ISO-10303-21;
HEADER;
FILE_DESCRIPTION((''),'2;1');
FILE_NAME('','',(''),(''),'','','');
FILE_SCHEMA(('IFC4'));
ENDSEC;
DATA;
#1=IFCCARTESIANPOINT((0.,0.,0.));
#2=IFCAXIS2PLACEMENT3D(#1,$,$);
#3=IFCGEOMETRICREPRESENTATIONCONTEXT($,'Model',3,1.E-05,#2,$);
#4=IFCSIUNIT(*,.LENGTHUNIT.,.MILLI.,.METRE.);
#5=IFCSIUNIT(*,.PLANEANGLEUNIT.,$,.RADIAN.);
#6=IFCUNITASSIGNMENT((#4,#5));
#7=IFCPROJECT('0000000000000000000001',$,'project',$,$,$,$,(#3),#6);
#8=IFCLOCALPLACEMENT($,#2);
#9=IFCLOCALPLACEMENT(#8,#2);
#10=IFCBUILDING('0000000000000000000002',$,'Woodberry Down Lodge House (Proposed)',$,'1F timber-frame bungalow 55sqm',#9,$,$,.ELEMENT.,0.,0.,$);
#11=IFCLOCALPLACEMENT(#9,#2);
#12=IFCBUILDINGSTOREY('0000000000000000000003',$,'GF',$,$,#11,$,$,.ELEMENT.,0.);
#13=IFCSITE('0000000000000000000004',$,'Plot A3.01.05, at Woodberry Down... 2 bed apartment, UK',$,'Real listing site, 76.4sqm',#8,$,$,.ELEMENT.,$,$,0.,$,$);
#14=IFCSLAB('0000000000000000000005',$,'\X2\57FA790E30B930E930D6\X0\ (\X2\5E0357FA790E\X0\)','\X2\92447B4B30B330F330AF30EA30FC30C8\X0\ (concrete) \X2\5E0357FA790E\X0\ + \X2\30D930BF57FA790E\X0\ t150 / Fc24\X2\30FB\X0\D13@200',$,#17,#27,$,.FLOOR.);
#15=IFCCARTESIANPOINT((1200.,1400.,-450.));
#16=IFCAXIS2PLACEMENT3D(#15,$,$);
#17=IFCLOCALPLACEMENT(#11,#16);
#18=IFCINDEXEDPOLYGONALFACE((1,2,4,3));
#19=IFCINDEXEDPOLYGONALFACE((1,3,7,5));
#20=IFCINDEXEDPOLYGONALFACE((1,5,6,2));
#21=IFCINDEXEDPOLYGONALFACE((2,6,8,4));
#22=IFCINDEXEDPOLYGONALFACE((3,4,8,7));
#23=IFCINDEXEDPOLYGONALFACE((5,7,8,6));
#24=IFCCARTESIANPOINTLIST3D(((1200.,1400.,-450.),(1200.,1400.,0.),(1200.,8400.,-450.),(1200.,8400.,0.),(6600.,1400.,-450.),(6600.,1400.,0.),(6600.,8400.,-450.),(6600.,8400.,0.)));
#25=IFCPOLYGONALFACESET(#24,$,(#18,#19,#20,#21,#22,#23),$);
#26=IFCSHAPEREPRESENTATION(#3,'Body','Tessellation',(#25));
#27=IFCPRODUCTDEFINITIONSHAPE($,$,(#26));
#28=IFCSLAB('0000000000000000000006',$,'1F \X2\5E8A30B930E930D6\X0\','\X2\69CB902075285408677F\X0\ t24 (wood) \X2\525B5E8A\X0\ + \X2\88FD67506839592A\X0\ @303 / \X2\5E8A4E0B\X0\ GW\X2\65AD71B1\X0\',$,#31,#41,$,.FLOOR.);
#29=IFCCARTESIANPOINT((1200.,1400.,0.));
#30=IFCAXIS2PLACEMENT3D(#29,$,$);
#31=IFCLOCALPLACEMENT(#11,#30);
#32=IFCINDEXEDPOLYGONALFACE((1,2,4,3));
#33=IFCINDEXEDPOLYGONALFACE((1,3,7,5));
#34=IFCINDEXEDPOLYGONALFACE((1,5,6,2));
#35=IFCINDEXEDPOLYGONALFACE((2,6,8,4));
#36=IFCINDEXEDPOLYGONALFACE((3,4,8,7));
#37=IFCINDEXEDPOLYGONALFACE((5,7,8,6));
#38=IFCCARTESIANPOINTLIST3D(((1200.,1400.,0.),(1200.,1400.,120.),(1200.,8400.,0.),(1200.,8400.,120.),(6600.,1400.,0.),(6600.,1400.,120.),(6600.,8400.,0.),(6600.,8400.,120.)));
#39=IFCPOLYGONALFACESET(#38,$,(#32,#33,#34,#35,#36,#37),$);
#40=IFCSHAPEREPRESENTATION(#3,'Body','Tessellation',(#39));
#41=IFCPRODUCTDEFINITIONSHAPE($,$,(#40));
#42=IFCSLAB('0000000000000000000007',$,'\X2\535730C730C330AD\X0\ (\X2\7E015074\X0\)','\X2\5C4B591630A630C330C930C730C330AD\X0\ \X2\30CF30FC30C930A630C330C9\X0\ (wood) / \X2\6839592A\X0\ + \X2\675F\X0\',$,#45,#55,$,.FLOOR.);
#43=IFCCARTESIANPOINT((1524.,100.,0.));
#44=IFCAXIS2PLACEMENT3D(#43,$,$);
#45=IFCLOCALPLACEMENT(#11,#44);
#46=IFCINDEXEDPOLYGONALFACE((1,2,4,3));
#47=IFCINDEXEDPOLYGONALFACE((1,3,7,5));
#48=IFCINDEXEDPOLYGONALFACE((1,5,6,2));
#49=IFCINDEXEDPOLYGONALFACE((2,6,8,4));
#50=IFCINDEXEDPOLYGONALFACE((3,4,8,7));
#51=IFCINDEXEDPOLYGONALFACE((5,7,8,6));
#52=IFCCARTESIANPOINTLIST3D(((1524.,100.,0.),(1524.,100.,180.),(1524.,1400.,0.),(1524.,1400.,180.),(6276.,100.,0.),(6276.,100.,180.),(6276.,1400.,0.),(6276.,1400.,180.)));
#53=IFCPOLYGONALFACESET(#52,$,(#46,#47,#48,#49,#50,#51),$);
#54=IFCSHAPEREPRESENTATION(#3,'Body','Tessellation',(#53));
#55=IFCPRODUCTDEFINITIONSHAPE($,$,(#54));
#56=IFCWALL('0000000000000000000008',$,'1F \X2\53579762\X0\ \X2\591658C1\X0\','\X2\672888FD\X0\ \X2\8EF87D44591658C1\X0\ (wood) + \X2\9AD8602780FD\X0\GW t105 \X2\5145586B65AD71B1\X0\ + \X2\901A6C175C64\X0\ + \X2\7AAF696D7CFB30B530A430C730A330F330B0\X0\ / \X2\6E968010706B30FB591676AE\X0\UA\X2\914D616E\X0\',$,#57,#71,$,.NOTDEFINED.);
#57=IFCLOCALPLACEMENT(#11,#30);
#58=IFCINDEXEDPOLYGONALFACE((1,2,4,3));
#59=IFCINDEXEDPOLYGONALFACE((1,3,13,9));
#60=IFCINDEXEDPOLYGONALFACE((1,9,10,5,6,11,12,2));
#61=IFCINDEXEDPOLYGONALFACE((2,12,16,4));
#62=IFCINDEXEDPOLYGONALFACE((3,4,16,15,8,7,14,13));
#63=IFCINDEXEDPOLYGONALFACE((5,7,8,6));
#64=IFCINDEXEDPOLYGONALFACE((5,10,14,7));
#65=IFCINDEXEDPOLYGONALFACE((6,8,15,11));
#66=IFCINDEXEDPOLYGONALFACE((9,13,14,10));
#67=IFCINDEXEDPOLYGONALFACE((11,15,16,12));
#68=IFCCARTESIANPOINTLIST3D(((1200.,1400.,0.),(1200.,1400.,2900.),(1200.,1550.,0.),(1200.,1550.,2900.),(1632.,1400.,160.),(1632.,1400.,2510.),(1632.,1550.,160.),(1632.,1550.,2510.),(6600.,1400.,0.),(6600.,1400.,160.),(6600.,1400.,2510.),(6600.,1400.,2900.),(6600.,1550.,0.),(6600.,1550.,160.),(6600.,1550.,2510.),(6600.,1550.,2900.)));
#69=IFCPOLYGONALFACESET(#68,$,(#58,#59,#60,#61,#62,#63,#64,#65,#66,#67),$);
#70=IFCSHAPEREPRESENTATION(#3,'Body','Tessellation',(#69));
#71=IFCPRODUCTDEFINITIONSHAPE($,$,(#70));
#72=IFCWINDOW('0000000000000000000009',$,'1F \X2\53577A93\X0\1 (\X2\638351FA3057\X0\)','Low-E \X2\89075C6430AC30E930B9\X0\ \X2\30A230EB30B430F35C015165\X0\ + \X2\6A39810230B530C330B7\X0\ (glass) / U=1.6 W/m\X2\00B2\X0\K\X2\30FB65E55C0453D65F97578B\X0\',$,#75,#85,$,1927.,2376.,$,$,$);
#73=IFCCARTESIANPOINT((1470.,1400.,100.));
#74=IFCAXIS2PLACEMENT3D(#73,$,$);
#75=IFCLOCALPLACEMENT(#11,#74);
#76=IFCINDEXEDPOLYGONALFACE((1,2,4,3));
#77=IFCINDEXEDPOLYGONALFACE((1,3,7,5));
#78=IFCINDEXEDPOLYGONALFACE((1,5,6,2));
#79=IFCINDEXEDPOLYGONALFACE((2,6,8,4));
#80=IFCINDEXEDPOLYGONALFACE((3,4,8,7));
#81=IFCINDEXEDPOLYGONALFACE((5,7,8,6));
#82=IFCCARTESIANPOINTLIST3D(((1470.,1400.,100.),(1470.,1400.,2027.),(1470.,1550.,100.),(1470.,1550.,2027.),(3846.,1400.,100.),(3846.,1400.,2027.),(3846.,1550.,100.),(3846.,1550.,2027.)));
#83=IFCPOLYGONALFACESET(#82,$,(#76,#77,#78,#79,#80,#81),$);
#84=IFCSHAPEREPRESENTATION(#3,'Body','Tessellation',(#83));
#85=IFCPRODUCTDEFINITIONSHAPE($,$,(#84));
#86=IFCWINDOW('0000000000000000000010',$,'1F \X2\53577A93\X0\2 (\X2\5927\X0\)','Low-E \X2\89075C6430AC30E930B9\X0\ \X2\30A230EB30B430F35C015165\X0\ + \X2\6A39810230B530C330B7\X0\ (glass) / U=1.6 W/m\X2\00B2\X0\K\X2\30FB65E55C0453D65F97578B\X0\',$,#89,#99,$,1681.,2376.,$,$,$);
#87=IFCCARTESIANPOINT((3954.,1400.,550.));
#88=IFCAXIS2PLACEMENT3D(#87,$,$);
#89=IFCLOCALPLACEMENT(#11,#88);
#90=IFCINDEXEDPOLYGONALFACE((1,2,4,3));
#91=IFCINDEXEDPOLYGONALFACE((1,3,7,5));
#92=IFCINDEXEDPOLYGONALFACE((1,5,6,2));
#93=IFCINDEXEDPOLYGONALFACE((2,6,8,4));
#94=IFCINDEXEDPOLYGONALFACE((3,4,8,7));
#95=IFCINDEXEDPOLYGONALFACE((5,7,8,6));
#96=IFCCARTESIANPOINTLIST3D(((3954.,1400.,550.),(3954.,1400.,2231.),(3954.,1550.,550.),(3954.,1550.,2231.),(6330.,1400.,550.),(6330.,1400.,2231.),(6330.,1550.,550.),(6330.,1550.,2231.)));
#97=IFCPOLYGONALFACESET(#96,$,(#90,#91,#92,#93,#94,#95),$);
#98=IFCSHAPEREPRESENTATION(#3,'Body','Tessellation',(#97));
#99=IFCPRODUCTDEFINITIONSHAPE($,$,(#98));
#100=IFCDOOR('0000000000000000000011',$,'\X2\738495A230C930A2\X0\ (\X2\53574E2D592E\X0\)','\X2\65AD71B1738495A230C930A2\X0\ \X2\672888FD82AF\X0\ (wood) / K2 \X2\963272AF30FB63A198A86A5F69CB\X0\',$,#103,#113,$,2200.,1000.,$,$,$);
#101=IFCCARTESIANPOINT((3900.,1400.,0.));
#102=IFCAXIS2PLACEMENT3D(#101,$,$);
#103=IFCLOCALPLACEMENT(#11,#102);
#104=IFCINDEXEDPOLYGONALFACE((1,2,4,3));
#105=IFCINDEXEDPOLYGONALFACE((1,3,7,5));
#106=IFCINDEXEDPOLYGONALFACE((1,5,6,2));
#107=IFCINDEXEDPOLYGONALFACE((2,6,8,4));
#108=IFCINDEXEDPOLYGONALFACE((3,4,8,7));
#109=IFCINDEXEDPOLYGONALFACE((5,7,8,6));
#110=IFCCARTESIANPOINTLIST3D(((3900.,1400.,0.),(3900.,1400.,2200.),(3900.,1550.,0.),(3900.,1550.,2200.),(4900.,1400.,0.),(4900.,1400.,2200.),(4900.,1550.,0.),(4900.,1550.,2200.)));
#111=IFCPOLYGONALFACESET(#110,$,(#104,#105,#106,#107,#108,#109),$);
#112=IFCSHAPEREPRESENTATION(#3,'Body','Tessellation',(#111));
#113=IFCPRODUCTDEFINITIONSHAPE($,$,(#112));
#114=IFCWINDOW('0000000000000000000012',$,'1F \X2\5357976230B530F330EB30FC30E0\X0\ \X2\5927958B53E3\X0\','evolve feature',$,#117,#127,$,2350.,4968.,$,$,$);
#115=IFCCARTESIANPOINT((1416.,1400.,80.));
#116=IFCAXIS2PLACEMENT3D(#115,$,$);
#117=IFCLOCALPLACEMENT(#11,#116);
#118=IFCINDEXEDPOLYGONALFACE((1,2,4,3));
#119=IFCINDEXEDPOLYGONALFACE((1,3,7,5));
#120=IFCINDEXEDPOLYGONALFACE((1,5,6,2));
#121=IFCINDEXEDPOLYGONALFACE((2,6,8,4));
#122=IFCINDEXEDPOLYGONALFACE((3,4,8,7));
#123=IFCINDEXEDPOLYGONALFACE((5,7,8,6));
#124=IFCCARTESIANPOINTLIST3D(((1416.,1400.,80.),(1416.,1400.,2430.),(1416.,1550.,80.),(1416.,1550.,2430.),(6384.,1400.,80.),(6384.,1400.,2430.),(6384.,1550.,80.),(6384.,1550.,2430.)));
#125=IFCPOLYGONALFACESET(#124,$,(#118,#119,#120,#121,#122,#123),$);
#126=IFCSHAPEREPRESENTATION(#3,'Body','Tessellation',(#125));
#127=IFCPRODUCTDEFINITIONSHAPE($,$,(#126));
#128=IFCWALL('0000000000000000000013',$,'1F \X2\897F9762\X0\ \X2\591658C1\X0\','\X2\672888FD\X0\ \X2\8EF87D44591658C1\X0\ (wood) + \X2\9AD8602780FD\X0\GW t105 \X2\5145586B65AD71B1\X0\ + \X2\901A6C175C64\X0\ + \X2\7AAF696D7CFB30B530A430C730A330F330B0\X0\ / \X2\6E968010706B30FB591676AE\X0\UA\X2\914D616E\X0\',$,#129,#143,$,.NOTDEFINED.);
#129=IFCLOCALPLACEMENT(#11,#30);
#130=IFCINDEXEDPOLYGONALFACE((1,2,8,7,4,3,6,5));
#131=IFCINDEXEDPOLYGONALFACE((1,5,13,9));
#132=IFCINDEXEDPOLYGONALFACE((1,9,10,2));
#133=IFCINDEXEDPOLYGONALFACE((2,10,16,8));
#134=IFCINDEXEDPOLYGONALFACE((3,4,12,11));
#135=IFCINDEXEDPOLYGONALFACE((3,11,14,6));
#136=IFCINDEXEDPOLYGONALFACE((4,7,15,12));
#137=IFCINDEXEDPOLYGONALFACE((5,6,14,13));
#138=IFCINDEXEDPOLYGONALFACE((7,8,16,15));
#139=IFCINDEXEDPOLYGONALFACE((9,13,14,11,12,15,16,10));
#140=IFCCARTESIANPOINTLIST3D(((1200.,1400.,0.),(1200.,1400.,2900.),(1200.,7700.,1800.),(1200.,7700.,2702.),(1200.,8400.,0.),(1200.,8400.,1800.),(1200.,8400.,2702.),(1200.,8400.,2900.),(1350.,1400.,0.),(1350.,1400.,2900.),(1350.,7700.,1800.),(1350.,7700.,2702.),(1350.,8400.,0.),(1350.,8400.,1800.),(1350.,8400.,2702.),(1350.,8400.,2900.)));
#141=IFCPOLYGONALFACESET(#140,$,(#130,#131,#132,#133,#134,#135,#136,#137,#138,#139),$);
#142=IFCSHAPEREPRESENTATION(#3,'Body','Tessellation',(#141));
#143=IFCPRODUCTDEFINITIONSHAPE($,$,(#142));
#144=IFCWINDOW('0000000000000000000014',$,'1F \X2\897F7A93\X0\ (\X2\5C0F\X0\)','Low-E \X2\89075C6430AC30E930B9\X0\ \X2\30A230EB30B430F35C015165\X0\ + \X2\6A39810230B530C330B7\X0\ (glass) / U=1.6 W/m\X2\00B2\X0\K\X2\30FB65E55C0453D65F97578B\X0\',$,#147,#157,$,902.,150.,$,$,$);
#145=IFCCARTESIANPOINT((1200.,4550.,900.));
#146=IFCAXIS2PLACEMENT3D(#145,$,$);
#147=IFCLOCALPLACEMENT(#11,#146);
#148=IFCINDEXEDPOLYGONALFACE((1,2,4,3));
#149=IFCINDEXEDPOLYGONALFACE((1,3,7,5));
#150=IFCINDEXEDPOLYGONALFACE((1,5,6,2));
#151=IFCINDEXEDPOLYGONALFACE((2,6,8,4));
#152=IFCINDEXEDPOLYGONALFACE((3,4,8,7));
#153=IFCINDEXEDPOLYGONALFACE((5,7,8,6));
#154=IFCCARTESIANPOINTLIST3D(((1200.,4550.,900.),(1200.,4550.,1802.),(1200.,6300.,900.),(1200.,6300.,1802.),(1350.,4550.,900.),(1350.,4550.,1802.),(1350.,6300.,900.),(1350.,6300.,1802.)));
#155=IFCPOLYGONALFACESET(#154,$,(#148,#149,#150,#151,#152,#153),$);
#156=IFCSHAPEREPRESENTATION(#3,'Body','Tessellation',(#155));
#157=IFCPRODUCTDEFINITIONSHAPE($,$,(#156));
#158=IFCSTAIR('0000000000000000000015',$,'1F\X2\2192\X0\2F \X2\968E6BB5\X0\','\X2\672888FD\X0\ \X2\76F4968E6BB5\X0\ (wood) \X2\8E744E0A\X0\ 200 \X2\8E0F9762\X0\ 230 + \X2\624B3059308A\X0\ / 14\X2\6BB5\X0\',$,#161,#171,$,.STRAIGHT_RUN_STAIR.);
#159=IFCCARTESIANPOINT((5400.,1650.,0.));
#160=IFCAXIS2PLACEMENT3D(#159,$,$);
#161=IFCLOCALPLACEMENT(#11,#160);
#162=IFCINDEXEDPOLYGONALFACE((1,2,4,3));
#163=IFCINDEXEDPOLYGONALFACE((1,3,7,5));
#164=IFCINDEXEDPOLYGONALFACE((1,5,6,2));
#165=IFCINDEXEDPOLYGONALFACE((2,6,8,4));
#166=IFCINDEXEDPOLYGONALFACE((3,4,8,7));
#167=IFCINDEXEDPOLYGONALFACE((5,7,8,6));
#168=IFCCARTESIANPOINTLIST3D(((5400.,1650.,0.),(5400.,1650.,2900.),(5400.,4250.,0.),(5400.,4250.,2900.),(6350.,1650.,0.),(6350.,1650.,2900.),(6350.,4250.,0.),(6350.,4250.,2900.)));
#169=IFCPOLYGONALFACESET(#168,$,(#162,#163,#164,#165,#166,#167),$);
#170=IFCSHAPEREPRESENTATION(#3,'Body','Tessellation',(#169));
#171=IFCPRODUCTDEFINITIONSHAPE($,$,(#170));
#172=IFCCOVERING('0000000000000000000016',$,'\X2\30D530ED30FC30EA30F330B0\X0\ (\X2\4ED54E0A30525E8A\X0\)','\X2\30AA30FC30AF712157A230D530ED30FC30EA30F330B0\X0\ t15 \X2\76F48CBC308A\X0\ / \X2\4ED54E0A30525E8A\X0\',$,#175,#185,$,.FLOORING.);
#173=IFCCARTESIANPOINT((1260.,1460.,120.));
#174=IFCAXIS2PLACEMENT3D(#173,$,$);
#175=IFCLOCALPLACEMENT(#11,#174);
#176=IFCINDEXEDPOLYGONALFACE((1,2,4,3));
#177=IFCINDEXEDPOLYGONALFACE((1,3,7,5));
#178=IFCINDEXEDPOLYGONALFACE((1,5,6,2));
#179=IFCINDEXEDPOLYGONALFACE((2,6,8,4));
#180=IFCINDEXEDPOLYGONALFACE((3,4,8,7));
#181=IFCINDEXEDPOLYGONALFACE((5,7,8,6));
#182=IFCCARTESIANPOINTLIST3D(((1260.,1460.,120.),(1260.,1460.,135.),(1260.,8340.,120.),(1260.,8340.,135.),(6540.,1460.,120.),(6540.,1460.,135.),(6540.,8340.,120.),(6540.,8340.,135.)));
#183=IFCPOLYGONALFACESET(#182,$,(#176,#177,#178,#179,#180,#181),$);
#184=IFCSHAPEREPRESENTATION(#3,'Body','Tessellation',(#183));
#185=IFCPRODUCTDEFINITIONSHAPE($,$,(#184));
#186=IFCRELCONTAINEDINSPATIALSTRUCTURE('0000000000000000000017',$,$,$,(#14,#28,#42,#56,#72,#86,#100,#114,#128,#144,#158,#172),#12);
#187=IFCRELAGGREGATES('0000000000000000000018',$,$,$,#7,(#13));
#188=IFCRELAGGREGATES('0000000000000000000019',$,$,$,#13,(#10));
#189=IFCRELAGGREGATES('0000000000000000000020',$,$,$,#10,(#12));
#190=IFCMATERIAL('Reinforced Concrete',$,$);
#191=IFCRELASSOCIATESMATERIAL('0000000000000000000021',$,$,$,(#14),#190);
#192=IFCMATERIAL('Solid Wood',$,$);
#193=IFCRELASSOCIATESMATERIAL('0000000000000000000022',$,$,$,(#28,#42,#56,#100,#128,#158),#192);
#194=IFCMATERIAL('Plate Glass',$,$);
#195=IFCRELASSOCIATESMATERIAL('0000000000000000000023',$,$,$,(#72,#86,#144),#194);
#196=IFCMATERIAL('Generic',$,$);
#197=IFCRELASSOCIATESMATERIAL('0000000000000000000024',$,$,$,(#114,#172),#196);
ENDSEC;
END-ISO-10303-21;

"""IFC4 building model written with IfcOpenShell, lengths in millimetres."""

from ifc_helpers import new_model, si_unit, frame, frame_2d, origin, place, context, project, spatial, rectangle, extrude, material, element, fill, save


model = new_model("IFC4")

# Units and contexts
model_context = context("Model", 3, precision=1e-05, world=origin())
ifc_project = project(units=[si_unit("LENGTHUNIT", "METRE", prefix="MILLI"), si_unit("PLANEANGLEUNIT", "RADIAN")], contexts=[model_context])

# Site, building, storey
site_placement = place(None, origin())
site = spatial("IfcSite", under=ifc_project, at=site_placement, Name="Plot A3.01.05, at Woodberry Down... 2 bed apartment, UK", ObjectType="Real listing site, 76.4sqm", CompositionType="ELEMENT", RefElevation=0.0)
building_placement = place(site_placement, origin())
building = spatial("IfcBuilding", under=site, at=building_placement, Name="Woodberry Down Lodge House (Proposed)", ObjectType="1F timber-frame bungalow 55sqm", CompositionType="ELEMENT", ElevationOfRefHeight=0.0, ElevationOfTerrain=0.0)
storey_placement = place(building_placement, origin())
storey = spatial("IfcBuildingStorey", under=building, at=storey_placement, Name="GF", CompositionType="ELEMENT", Elevation=0.0)

# Slabs
ifc_material_1 = material(Name="Reinforced Concrete")
slab_1_placement = place(storey_placement, frame((1200.0, 1400.0, -450.0)))
element("IfcSlab", 1, at=slab_1_placement, inside=storey, material=ifc_material_1, Name="基礎スラブ (布基礎)", Description="鉄筋コンクリート (concrete) 布基礎 + ベタ基礎 t150 / Fc24・D13@200", PredefinedType="FLOOR", context=model_context, shape_type="SweptSolid", body=[
    extrude(rectangle(XDim=5400.0, YDim=7000.0, at=frame_2d((2700.0, 3500.0))), frame((1200.0, 1400.0, -450.0)), (0.0, 0.0, 1.0), 450.0),
])
ifc_material_2 = material(Name="Solid Wood")
slab_2_placement = place(storey_placement, frame((1200.0, 1400.0, 0.0)))
element("IfcSlab", 2, at=slab_2_placement, inside=storey, material=ifc_material_2, Name="1F 床スラブ", Description="構造用合板 t24 (wood) 剛床 + 製材根太 @303 / 床下 GW断熱", PredefinedType="FLOOR", context=model_context, shape_type="SweptSolid", body=[
    extrude(rectangle(XDim=5400.0, YDim=7000.0, at=frame_2d((2700.0, 3500.0))), frame((1200.0, 1400.0, 0.0)), (0.0, 0.0, 1.0), 120.0),
])
slab_3_placement = place(storey_placement, frame((1524.0, 100.0, 0.0)))
element("IfcSlab", 3, at=slab_3_placement, inside=storey, material=ifc_material_2, Name="南デッキ (縁側)", Description="屋外ウッドデッキ ハードウッド (wood) / 根太 + 束", PredefinedType="FLOOR", context=model_context, shape_type="SweptSolid", body=[
    extrude(rectangle(XDim=4752.0, YDim=1300.0, at=frame_2d((2376.0, 650.0))), frame((1524.0, 100.0, 0.0)), (0.0, 0.0, 1.0), 180.0),
])
ifc_material_3 = material(Name="Generic")

# Wall, openings, windows, door
wall_1_placement = place(storey_placement, frame((1200.0, 1400.0, 0.0)))
wall_1 = element("IfcWall", 4, at=wall_1_placement, inside=storey, material=ifc_material_2, Name="1F 南面 外壁", Description="木製 軸組外壁 (wood) + 高性能GW t105 充填断熱 + 通気層 + 窯業系サイディング / 準耐火・外皮UA配慮", PredefinedType="NOTDEFINED", context=model_context, shape_type="SweptSolid", body=[
    extrude(rectangle(XDim=5400.0, YDim=150.0, at=frame_2d((2700.0, 75.0))), frame((1200.0, 1400.0, 0.0)), (0.0, 0.0, 1.0), 2900.0),
])
opening_1_placement = place(storey_placement, frame((1470.0, 1400.0, 100.0)))
opening_1 = element("IfcOpeningElement", 5, at=opening_1_placement, cuts=wall_1, PredefinedType="NOTDEFINED", context=model_context, shape_type="SweptSolid", body=[
    extrude(rectangle(XDim=2376.0, YDim=150.0, at=frame_2d((1188.0, 75.0))), frame((1470.0, 1400.0, 100.0)), (0.0, 0.0, 1.0), 1927.0),
])
opening_2_placement = place(storey_placement, frame((3954.0, 1400.0, 550.0)))
opening_2 = element("IfcOpeningElement", 6, at=opening_2_placement, cuts=wall_1, PredefinedType="NOTDEFINED", context=model_context, shape_type="SweptSolid", body=[
    extrude(rectangle(XDim=2376.0, YDim=150.0, at=frame_2d((1188.0, 75.0))), frame((3954.0, 1400.0, 550.0)), (0.0, 0.0, 1.0), 1681.0),
])
opening_3_placement = place(storey_placement, frame((3900.0, 1400.0, 0.0)))
opening_3 = element("IfcOpeningElement", 7, at=opening_3_placement, cuts=wall_1, PredefinedType="NOTDEFINED", context=model_context, shape_type="SweptSolid", body=[
    extrude(rectangle(XDim=1000.0, YDim=150.0, at=frame_2d((500.0, 75.0))), frame((3900.0, 1400.0, 0.0)), (0.0, 0.0, 1.0), 2200.0),
])
opening_4_placement = place(storey_placement, frame((1416.0, 1400.0, 80.0)))
opening_4 = element("IfcOpeningElement", 8, at=opening_4_placement, cuts=wall_1, PredefinedType="NOTDEFINED", context=model_context, shape_type="SweptSolid", body=[
    extrude(rectangle(XDim=4968.0, YDim=150.0, at=frame_2d((2484.0, 75.0))), frame((1416.0, 1400.0, 80.0)), (0.0, 0.0, 1.0), 2350.0),
])
ifc_material_4 = material(Name="Plate Glass")
window_1_placement = place(storey_placement, frame((1470.0, 1400.0, 100.0)))
window_1 = element("IfcWindow", 9, at=window_1_placement, inside=storey, material=ifc_material_4, Name="1F 南窓1 (掃出し)", Description="Low-E 複層ガラス アルゴン封入 + 樹脂サッシ (glass) / U=1.6 W/m²K・日射取得型", OverallHeight=1927.0, OverallWidth=2376.0, context=model_context, shape_type="SweptSolid", body=[
    extrude(rectangle(XDim=2376.0, YDim=150.0, at=frame_2d((1188.0, 75.0))), frame((1470.0, 1400.0, 100.0)), (0.0, 0.0, 1.0), 1927.0),
])
fill(opening_1, window_1)
window_2_placement = place(storey_placement, frame((3954.0, 1400.0, 550.0)))
window_2 = element("IfcWindow", 10, at=window_2_placement, inside=storey, material=ifc_material_4, Name="1F 南窓2 (大)", Description="Low-E 複層ガラス アルゴン封入 + 樹脂サッシ (glass) / U=1.6 W/m²K・日射取得型", OverallHeight=1681.0, OverallWidth=2376.0, context=model_context, shape_type="SweptSolid", body=[
    extrude(rectangle(XDim=2376.0, YDim=150.0, at=frame_2d((1188.0, 75.0))), frame((3954.0, 1400.0, 550.0)), (0.0, 0.0, 1.0), 1681.0),
])
fill(opening_2, window_2)
door_placement = place(storey_placement, frame((3900.0, 1400.0, 0.0)))
door = element("IfcDoor", 11, at=door_placement, inside=storey, material=ifc_material_2, Name="玄関ドア (南中央)", Description="断熱玄関ドア 木製芯 (wood) / K2 防犯・採風機構", OverallHeight=2200.0, OverallWidth=1000.0, context=model_context, shape_type="SweptSolid", body=[
    extrude(rectangle(XDim=1000.0, YDim=150.0, at=frame_2d((500.0, 75.0))), frame((3900.0, 1400.0, 0.0)), (0.0, 0.0, 1.0), 2200.0),
])
fill(opening_3, door)
window_3_placement = place(storey_placement, frame((1416.0, 1400.0, 80.0)))
window_3 = element("IfcWindow", 12, at=window_3_placement, inside=storey, material=ifc_material_3, Name="1F 南面サンルーム 大開口", Description="evolve feature", OverallHeight=2350.0, OverallWidth=4968.0, context=model_context, shape_type="SweptSolid", body=[
    extrude(rectangle(XDim=4968.0, YDim=150.0, at=frame_2d((2484.0, 75.0))), frame((1416.0, 1400.0, 80.0)), (0.0, 0.0, 1.0), 2350.0),
])
fill(opening_4, window_3)

# Wall, opening, window
wall_2_placement = place(storey_placement, frame((1200.0, 1400.0, 0.0)))
wall_2 = element("IfcWall", 13, at=wall_2_placement, inside=storey, material=ifc_material_2, Name="1F 西面 外壁", Description="木製 軸組外壁 (wood) + 高性能GW t105 充填断熱 + 通気層 + 窯業系サイディング / 準耐火・外皮UA配慮", PredefinedType="NOTDEFINED", context=model_context, shape_type="SweptSolid", body=[
    extrude(rectangle(XDim=150.0, YDim=7000.0, at=frame_2d((75.0, 3500.0))), frame((1200.0, 1400.0, 0.0)), (0.0, 0.0, 1.0), 2900.0),
])
opening_5_placement = place(storey_placement, frame((1200.0, 4550.0, 900.0)))
opening_5 = element("IfcOpeningElement", 14, at=opening_5_placement, cuts=wall_2, PredefinedType="NOTDEFINED", context=model_context, shape_type="SweptSolid", body=[
    extrude(rectangle(XDim=150.0, YDim=1750.0, at=frame_2d((75.0, 875.0))), frame((1200.0, 4550.0, 900.0)), (0.0, 0.0, 1.0), 902.0),
])
window_4_placement = place(storey_placement, frame((1200.0, 4550.0, 900.0)))
window_4 = element("IfcWindow", 15, at=window_4_placement, inside=storey, material=ifc_material_4, Name="1F 西窓 (小)", Description="Low-E 複層ガラス アルゴン封入 + 樹脂サッシ (glass) / U=1.6 W/m²K・日射取得型", OverallHeight=902.0, OverallWidth=150.0, context=model_context, shape_type="SweptSolid", body=[
    extrude(rectangle(XDim=150.0, YDim=1750.0, at=frame_2d((75.0, 875.0))), frame((1200.0, 4550.0, 900.0)), (0.0, 0.0, 1.0), 902.0),
])
fill(opening_5, window_4)

# Stair
stair_placement = place(storey_placement, frame((5400.0, 1650.0, 0.0)))
element("IfcStair", 16, at=stair_placement, inside=storey, material=ifc_material_2, Name="1F→2F 階段", Description="木製 直階段 (wood) 蹴上 200 踏面 230 + 手すり / 14段", PredefinedType="STRAIGHT_RUN_STAIR", context=model_context, shape_type="SweptSolid", body=[
    extrude(rectangle(XDim=950.0, YDim=2600.0, at=frame_2d((475.0, 1300.0))), frame((5400.0, 1650.0, 0.0)), (0.0, 0.0, 1.0), 2900.0),
])

# Covering
covering_placement = place(storey_placement, frame((1260.0, 1460.0, 120.0)))
element("IfcCovering", 17, at=covering_placement, inside=storey, material=ifc_material_3, Name="フローリング (仕上げ床)", Description="オーク無垢フローリング t15 直貼り / 仕上げ床", PredefinedType="FLOORING", context=model_context, shape_type="SweptSolid", body=[
    extrude(rectangle(XDim=5280.0, YDim=6880.0, at=frame_2d((2640.0, 3440.0))), frame((1260.0, 1460.0, 120.0)), (0.0, 0.0, 1.0), 15.0),
])

save(model, "model.ifc")
